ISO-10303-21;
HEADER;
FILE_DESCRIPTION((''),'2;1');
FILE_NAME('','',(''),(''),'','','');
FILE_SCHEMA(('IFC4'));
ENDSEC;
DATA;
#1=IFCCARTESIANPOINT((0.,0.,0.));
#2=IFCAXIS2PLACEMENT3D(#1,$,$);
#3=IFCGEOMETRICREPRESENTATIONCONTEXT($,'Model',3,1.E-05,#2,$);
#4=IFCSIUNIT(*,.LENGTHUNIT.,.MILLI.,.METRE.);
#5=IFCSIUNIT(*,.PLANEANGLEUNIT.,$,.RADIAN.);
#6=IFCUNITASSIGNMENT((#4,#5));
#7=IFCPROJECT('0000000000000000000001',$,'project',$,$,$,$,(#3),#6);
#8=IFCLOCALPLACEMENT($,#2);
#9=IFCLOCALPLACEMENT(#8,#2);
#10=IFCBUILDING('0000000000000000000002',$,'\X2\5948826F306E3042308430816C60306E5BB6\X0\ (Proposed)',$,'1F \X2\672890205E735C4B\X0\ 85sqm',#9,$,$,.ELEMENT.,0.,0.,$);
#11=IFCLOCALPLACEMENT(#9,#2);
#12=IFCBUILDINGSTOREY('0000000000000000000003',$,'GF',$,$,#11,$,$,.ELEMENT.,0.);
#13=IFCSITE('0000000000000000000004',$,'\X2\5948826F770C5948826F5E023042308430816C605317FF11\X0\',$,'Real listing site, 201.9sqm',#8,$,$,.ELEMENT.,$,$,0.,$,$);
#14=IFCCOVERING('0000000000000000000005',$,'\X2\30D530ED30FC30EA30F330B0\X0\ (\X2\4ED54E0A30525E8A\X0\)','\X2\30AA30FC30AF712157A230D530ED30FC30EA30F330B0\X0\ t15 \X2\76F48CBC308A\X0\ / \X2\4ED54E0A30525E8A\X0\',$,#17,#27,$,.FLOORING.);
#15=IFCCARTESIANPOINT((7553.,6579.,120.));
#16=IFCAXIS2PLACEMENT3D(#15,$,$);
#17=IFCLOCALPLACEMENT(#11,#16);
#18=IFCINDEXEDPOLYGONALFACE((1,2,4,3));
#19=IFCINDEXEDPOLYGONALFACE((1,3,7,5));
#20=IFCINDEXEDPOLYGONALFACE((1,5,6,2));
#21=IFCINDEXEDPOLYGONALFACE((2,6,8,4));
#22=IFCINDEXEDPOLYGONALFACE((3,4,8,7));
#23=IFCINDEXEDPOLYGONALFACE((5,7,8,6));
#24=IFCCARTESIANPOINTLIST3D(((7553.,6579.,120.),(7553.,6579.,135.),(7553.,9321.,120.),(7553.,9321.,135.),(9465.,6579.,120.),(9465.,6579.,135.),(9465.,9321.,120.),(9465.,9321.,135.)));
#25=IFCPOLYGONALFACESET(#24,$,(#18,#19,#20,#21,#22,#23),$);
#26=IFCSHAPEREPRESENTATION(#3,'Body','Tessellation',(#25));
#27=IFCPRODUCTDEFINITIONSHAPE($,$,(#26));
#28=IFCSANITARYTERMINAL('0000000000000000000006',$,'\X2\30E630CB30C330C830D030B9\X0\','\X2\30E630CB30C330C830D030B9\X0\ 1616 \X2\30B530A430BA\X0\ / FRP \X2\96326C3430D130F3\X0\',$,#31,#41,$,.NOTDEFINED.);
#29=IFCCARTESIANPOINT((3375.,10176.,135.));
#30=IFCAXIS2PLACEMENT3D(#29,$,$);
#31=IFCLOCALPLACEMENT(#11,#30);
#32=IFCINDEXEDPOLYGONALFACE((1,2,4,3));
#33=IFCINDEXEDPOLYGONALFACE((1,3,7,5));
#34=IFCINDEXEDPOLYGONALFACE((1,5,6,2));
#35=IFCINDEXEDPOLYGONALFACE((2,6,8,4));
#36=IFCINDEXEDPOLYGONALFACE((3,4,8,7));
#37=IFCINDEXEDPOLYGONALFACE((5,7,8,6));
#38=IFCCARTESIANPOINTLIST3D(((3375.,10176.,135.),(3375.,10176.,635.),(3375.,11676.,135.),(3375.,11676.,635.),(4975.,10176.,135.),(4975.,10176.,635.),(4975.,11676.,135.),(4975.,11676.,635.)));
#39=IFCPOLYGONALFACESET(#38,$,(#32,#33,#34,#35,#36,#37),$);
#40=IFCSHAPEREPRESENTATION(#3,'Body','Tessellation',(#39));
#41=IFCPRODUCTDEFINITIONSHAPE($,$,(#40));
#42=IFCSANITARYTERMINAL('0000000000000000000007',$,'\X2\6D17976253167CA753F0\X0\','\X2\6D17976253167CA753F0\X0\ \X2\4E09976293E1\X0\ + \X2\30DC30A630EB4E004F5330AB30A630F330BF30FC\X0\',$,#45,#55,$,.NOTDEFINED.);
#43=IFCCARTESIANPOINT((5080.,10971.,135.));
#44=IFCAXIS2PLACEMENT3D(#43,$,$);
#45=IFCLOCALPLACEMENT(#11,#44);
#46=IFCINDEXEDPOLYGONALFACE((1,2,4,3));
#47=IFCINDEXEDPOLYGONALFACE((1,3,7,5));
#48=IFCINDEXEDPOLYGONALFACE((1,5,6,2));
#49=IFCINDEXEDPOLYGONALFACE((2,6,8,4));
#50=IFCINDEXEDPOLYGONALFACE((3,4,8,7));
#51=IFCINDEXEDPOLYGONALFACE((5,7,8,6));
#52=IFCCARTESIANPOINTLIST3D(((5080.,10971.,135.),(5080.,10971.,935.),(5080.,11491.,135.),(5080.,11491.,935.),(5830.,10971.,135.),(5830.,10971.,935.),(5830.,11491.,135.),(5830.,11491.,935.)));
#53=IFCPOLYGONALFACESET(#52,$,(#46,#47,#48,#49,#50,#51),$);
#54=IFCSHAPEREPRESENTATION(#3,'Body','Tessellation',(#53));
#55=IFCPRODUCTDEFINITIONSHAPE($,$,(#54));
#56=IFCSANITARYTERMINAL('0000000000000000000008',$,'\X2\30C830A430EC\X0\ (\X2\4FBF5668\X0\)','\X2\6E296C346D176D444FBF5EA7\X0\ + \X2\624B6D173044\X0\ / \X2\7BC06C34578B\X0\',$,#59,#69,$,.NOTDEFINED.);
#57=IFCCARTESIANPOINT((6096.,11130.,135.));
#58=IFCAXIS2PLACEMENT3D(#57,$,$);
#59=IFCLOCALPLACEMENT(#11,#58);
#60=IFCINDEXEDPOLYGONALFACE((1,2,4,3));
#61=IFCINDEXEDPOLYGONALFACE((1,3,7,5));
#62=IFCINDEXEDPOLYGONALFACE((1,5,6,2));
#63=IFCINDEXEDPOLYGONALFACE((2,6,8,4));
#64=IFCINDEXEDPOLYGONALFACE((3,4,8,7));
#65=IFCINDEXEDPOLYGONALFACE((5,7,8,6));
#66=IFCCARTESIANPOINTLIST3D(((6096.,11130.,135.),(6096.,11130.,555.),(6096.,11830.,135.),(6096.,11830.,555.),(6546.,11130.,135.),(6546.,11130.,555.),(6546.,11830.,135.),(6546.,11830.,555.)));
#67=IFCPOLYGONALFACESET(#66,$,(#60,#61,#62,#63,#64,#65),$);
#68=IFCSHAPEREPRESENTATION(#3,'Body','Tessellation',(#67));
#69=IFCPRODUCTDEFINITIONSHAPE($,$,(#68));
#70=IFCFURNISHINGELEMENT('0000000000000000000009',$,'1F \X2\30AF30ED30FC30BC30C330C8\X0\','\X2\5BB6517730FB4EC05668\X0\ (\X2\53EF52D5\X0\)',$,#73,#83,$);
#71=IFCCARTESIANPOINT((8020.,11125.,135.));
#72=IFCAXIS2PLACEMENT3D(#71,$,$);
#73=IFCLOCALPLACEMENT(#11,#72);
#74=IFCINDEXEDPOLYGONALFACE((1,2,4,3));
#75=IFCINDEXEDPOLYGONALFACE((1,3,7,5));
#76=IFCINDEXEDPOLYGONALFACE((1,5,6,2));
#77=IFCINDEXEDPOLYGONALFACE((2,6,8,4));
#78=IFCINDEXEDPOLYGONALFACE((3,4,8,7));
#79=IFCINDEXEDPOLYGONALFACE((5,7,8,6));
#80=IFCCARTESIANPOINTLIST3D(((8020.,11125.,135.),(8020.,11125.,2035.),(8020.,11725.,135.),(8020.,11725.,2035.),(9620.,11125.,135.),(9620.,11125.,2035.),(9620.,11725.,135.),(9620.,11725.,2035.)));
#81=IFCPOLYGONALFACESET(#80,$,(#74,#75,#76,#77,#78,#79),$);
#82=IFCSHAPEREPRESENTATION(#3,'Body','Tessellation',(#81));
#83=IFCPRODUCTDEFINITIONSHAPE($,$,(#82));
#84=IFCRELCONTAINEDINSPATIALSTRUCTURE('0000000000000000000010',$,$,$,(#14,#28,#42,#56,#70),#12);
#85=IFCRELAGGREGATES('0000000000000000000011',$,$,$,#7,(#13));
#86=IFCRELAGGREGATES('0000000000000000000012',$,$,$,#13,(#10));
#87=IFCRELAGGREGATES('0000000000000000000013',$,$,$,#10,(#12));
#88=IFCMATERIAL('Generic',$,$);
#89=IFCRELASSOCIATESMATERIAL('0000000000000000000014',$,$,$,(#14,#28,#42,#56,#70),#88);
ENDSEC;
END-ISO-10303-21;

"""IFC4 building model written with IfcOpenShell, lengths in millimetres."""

from ifc_helpers import new_model, si_unit, frame, frame_2d, origin, place, context, project, spatial, rectangle, extrude, material, element, save


model = new_model("IFC4")

# Units and contexts
model_context = context("Model", 3, precision=1e-05, world=origin())
ifc_project = project(units=[si_unit("LENGTHUNIT", "METRE", prefix="MILLI"), si_unit("PLANEANGLEUNIT", "RADIAN")], contexts=[model_context])

# Site, building, storey
site_placement = place(None, origin())
site = spatial("IfcSite", under=ifc_project, at=site_placement, Name="奈良県奈良市あやめ池北１", ObjectType="Real listing site, 201.9sqm", CompositionType="ELEMENT", RefElevation=0.0)
building_placement = place(site_placement, origin())
building = spatial("IfcBuilding", under=site, at=building_placement, Name="奈良のあやめ池の家 (Proposed)", ObjectType="1F 木造平屋 85sqm", CompositionType="ELEMENT", ElevationOfRefHeight=0.0, ElevationOfTerrain=0.0)
storey_placement = place(building_placement, origin())
storey = spatial("IfcBuildingStorey", under=building, at=storey_placement, Name="GF", CompositionType="ELEMENT", Elevation=0.0)

# Covering
ifc_material_1 = material(Name="Generic")
covering_1_placement = place(storey_placement, frame((7553.0, 6579.0, 120.0)))
element("IfcCovering", 1, at=covering_1_placement, inside=storey, material=ifc_material_1, Name="フローリング (仕上げ床)", Description="オーク無垢フローリング t15 直貼り / 仕上げ床", PredefinedType="FLOORING", context=model_context, shape_type="SweptSolid", body=[
    extrude(rectangle(XDim=1912.0, YDim=2742.0, at=frame_2d((956.0, 1371.0))), frame((7553.0, 6579.0, 120.0)), (0.0, 0.0, 1.0), 15.0),
])

# Sanitary terminals
sanitary_terminal_1_placement = place(storey_placement, frame((3375.0, 10176.0, 135.0)))
element("IfcSanitaryTerminal", 2, at=sanitary_terminal_1_placement, inside=storey, material=ifc_material_1, Name="ユニットバス", Description="ユニットバス 1616 サイズ / FRP 防水パン", PredefinedType="NOTDEFINED", context=model_context, shape_type="SweptSolid", body=[
    extrude(rectangle(XDim=1600.0, YDim=1500.0, at=frame_2d((800.0, 750.0))), frame((3375.0, 10176.0, 135.0)), (0.0, 0.0, 1.0), 500.0),
])
sanitary_terminal_2_placement = place(storey_placement, frame((5080.0, 10971.0, 135.0)))
element("IfcSanitaryTerminal", 3, at=sanitary_terminal_2_placement, inside=storey, material=ifc_material_1, Name="洗面化粧台", Description="洗面化粧台 三面鏡 + ボウル一体カウンター", PredefinedType="NOTDEFINED", context=model_context, shape_type="SweptSolid", body=[
    extrude(rectangle(XDim=750.0, YDim=520.0, at=frame_2d((375.0, 260.0))), frame((5080.0, 10971.0, 135.0)), (0.0, 0.0, 1.0), 800.0),
])
sanitary_terminal_3_placement = place(storey_placement, frame((6096.0, 11130.0, 135.0)))
element("IfcSanitaryTerminal", 4, at=sanitary_terminal_3_placement, inside=storey, material=ifc_material_1, Name="トイレ (便器)", Description="温水洗浄便座 + 手洗い / 節水型", PredefinedType="NOTDEFINED", context=model_context, shape_type="SweptSolid", body=[
    extrude(rectangle(XDim=450.0, YDim=700.0, at=frame_2d((225.0, 350.0))), frame((6096.0, 11130.0, 135.0)), (0.0, 0.0, 1.0), 420.0),
])

# Furnishing element
furnishing_placement = place(storey_placement, frame((8020.0, 11125.0, 135.0)))
element("IfcFurnishingElement", 5, at=furnishing_placement, inside=storey, material=ifc_material_1, Name="1F クローゼット", Description="家具・什器 (可動)", context=model_context, shape_type="SweptSolid", body=[
    extrude(rectangle(XDim=1600.0, YDim=600.0, at=frame_2d((800.0, 300.0))), frame((8020.0, 11125.0, 135.0)), (0.0, 0.0, 1.0), 1900.0),
])

save(model, "model.ifc")
